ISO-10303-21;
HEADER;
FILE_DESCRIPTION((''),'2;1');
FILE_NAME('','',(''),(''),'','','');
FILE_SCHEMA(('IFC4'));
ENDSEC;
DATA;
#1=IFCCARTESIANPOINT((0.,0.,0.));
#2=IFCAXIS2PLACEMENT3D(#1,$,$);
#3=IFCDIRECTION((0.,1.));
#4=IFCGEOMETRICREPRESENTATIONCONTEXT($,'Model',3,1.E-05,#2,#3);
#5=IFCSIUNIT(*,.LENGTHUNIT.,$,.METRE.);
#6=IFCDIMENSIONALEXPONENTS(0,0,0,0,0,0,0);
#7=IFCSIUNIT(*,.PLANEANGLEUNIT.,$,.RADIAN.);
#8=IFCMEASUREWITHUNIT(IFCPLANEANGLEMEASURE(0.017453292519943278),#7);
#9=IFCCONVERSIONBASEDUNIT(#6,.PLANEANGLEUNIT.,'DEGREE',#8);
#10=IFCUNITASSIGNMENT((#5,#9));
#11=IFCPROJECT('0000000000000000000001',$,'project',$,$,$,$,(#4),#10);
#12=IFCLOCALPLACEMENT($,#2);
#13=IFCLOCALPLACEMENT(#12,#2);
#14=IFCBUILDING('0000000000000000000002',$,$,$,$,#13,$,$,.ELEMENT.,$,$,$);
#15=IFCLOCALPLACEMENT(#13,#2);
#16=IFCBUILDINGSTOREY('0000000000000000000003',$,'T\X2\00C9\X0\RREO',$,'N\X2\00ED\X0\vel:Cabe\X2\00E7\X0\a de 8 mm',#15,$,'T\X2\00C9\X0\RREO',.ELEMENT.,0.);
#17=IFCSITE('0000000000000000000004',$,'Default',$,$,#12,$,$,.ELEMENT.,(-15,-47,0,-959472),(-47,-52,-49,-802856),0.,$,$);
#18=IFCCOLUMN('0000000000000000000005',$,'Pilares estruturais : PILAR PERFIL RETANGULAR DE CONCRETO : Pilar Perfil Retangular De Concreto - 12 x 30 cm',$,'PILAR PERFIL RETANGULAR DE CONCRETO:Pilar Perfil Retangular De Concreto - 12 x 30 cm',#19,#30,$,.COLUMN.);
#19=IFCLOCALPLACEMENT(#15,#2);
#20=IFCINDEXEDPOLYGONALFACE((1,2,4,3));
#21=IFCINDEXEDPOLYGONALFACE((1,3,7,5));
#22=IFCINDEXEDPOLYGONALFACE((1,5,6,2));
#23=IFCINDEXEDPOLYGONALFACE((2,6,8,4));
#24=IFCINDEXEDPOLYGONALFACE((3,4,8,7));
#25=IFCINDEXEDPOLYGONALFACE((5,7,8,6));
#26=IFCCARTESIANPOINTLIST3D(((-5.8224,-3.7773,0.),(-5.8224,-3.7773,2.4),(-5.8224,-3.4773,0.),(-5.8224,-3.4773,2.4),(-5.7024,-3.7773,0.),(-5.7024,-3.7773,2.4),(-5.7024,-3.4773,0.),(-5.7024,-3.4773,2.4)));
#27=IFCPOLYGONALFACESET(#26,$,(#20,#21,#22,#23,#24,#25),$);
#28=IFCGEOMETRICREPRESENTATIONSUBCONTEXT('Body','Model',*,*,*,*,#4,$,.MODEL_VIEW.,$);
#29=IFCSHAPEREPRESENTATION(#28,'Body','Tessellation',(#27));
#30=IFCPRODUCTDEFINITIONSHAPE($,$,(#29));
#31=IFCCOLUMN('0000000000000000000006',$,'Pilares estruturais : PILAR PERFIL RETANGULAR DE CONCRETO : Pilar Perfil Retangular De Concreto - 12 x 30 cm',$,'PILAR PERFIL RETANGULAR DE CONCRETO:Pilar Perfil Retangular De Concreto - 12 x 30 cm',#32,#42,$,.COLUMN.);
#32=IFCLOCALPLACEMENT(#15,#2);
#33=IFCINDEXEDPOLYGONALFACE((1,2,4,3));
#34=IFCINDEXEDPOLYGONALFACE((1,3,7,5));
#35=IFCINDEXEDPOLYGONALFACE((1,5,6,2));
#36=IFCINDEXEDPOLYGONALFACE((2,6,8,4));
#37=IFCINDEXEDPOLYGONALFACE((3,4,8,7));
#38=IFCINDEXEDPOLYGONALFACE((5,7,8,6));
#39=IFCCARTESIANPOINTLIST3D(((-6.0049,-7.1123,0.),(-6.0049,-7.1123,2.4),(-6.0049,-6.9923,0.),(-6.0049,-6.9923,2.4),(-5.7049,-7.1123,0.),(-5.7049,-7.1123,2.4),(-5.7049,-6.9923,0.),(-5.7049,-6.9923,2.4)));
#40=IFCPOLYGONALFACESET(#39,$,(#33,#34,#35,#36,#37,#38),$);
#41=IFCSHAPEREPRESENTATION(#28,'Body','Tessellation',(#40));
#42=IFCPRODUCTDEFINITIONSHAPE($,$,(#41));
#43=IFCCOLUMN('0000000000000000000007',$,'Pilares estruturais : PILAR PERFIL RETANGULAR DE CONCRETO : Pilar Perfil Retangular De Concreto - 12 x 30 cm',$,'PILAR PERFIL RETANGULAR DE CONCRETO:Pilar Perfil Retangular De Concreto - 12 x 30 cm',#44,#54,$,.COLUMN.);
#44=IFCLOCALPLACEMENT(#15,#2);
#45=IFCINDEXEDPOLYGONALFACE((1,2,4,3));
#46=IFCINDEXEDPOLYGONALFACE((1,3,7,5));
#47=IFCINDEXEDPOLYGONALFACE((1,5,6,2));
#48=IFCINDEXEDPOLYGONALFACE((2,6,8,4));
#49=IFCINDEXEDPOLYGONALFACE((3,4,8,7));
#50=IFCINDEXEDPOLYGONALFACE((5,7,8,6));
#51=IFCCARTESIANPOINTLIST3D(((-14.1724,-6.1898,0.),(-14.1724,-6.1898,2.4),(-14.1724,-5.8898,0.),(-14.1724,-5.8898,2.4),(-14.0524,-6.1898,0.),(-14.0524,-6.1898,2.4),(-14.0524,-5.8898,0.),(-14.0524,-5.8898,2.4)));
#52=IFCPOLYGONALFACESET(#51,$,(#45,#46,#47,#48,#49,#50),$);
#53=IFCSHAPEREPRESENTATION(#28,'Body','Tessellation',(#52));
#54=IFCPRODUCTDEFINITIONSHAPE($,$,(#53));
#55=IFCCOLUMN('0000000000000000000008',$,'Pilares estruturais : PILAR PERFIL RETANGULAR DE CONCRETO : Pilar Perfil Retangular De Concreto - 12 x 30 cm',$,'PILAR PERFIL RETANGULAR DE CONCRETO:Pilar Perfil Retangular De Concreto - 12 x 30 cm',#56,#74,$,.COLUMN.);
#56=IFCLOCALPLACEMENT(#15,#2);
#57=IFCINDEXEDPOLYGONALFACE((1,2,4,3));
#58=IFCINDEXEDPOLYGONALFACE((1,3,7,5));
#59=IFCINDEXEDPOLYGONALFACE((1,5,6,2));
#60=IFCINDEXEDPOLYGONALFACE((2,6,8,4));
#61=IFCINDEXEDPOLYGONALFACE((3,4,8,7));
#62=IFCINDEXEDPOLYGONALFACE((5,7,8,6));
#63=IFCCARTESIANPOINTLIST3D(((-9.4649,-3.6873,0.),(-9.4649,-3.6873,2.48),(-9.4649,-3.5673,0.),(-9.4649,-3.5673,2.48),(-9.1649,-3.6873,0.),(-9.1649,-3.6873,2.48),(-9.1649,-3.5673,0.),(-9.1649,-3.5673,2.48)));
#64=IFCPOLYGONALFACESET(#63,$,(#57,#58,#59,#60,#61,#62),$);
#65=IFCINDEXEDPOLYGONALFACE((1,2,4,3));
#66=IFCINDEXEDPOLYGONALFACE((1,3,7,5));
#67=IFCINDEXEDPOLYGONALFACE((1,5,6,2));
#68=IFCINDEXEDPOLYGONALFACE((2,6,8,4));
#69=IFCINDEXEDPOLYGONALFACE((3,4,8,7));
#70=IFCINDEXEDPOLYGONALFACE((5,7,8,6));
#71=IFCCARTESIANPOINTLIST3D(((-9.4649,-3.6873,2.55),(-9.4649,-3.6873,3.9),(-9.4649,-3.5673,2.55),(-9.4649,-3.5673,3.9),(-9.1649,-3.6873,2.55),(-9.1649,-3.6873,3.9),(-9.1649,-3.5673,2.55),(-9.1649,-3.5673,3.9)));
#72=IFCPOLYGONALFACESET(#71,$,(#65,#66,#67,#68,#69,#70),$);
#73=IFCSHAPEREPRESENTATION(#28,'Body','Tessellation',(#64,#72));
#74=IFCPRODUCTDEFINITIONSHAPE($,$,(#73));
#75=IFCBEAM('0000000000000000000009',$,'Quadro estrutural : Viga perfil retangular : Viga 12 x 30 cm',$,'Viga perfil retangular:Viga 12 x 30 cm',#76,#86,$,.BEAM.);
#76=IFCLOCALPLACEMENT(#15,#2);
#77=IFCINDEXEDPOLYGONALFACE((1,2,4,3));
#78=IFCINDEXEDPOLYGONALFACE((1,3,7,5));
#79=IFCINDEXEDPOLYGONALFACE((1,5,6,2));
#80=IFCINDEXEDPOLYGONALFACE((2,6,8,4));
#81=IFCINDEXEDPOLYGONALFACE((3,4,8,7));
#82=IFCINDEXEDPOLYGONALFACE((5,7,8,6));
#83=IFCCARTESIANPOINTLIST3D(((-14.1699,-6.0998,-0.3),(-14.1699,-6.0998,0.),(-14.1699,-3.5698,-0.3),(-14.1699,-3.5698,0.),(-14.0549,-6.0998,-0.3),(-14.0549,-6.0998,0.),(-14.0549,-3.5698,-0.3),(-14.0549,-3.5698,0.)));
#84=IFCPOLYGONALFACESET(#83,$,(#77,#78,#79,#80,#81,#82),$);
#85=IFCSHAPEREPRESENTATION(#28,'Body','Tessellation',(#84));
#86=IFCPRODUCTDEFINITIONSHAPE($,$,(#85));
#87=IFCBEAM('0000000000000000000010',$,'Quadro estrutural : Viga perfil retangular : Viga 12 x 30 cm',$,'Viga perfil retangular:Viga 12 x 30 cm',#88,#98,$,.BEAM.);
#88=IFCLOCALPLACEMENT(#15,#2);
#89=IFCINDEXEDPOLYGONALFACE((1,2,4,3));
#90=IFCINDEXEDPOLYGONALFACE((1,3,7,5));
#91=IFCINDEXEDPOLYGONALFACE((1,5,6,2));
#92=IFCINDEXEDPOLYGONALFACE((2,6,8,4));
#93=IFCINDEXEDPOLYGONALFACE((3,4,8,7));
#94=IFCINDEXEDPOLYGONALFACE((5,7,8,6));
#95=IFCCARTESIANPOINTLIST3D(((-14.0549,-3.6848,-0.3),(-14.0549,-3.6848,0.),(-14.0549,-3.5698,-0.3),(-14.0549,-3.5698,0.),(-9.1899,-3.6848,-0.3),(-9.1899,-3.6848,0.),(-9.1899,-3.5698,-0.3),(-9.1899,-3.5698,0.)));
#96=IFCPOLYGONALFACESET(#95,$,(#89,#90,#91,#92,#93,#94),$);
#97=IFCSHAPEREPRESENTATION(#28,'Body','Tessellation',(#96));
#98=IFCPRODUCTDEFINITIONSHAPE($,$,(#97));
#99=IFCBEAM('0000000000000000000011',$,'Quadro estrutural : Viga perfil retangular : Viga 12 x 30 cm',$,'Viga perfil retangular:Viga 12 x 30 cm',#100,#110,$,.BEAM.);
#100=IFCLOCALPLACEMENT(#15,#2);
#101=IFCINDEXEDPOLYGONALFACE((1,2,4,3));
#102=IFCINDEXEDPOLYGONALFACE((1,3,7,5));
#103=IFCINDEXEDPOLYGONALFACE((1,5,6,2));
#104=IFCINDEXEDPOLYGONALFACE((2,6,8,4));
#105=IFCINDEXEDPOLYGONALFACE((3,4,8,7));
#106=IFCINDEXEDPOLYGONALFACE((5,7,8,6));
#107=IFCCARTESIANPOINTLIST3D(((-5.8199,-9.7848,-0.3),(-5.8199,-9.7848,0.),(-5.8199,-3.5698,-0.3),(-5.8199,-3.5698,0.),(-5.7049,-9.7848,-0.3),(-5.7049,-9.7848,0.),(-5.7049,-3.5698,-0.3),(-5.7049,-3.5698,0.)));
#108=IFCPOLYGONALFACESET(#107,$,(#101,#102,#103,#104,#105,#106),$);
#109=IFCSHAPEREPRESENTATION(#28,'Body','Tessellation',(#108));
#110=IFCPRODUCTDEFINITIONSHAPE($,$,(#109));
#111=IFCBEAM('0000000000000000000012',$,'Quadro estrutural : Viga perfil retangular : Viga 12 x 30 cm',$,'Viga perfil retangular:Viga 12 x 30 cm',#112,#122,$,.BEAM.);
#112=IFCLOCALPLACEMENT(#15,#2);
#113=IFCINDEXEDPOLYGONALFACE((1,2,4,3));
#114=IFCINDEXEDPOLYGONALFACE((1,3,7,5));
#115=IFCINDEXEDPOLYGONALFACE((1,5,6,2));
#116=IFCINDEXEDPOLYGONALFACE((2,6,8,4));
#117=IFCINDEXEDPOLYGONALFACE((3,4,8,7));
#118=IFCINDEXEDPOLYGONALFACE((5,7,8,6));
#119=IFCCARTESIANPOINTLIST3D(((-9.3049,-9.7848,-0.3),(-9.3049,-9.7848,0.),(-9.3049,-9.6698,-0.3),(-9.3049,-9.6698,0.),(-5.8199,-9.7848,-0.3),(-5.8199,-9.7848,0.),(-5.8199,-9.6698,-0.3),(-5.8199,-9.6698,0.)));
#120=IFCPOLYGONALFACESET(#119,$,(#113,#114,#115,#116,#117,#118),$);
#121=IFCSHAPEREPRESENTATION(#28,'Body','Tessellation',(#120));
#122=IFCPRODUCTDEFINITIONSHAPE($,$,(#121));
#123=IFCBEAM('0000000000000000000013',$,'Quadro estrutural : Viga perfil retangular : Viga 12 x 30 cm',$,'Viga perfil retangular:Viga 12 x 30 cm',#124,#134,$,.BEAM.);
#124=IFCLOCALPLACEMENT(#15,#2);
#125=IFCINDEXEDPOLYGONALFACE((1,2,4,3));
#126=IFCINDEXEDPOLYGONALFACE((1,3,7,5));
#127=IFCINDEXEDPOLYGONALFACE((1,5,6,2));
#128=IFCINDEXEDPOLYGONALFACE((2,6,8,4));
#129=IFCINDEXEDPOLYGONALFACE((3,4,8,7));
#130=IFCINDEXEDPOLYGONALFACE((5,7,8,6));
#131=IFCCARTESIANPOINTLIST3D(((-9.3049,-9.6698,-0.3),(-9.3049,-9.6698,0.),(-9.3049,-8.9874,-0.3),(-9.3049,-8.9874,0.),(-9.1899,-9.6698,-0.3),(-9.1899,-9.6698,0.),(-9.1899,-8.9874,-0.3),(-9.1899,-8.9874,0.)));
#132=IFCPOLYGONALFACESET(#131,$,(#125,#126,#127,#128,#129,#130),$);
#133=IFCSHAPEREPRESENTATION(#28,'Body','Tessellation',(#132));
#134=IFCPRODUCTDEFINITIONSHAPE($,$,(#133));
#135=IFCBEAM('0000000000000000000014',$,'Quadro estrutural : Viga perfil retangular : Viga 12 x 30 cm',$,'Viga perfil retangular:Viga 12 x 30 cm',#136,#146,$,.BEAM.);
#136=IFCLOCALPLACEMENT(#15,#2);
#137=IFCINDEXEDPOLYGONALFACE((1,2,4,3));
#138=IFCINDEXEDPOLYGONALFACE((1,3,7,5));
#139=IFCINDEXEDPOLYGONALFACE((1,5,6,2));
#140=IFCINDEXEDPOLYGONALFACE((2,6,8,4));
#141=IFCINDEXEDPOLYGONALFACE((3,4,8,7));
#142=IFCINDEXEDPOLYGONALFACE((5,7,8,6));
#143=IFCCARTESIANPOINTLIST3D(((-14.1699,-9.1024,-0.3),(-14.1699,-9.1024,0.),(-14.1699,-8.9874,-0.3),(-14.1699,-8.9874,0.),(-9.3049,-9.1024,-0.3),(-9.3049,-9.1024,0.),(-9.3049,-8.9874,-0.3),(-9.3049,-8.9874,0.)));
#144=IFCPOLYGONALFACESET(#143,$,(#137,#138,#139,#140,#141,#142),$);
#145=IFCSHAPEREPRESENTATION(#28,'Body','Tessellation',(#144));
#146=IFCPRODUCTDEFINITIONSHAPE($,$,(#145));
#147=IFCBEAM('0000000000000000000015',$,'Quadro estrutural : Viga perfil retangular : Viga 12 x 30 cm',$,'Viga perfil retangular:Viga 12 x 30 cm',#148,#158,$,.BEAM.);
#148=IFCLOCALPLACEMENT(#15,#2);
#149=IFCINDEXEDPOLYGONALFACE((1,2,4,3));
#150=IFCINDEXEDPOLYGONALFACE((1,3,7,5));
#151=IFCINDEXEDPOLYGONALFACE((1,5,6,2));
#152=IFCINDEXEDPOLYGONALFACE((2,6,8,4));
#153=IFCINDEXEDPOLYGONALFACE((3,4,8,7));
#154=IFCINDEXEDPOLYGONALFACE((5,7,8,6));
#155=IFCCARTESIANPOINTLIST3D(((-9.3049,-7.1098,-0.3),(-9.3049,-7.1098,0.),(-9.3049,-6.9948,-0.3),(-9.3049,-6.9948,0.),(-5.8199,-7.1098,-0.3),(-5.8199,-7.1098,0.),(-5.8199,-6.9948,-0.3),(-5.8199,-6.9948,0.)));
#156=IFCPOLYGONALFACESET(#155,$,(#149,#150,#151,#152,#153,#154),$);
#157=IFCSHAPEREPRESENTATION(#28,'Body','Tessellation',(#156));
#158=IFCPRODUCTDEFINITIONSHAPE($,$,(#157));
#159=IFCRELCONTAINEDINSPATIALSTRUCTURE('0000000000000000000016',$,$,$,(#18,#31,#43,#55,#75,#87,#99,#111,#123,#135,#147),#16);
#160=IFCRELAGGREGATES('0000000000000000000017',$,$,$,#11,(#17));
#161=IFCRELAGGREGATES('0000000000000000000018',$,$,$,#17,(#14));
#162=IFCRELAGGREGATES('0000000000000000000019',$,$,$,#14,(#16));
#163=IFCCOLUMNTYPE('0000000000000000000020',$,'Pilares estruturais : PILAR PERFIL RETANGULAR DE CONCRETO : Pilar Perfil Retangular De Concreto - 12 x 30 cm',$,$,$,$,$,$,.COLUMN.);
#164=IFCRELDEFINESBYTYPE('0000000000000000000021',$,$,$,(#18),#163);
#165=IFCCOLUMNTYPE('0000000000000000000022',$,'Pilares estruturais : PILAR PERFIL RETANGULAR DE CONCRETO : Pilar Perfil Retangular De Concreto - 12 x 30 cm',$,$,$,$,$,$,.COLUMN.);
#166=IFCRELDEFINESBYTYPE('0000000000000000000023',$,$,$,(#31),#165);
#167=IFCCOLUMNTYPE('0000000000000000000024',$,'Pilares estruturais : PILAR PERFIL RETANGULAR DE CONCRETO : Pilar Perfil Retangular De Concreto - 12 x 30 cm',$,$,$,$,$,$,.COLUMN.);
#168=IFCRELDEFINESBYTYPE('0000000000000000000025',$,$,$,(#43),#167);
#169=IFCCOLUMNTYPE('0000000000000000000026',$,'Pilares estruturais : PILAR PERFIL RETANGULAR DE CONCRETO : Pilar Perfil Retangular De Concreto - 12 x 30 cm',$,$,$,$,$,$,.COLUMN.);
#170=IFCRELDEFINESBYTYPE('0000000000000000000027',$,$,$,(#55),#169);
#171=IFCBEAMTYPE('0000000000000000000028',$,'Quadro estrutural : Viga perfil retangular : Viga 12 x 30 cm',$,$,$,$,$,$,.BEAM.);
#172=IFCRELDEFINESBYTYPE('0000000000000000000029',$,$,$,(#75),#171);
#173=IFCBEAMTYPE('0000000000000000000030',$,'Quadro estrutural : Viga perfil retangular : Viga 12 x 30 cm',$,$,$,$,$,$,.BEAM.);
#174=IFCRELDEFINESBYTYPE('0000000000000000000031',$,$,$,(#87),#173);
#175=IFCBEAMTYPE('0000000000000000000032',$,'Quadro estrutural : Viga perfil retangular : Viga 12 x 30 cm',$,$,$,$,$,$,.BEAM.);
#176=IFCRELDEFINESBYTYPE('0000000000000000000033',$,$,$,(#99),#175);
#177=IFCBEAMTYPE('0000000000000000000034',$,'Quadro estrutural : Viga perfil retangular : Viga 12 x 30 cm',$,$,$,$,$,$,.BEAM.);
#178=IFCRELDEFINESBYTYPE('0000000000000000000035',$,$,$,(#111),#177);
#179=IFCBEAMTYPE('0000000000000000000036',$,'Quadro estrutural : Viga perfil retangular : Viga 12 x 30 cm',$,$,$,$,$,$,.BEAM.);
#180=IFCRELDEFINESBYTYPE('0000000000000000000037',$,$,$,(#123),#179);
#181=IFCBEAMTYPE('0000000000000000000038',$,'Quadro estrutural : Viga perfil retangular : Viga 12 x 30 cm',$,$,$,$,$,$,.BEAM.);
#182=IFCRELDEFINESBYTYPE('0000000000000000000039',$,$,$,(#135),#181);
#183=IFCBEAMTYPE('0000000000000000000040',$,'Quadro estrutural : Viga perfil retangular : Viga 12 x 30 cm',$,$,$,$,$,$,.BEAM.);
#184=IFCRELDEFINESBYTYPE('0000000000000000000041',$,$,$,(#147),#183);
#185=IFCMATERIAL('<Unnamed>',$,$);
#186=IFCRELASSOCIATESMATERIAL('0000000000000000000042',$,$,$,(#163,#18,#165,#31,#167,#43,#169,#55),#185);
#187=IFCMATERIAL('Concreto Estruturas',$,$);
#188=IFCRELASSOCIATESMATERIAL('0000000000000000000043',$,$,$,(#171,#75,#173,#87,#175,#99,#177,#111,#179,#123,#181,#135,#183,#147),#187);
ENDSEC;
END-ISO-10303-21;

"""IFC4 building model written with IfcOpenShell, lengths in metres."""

from ifc_helpers import new_model, entity, si_unit, converted_unit, direction, frame, origin, place, context, subcontext, project, spatial, indexed_curve, outline, extrude, source, transform, mapped, material, type_object, type_shapes, element, save


model = new_model("IFC4")

# Units and contexts
model_context = context("Model", 3, precision=1e-05, world=origin(), true_north=direction((0.0, 1.0)))
body_context = subcontext(model_context, "Body", "Model", "MODEL_VIEW")
ifc_project = project(units=[si_unit("LENGTHUNIT", "METRE"), converted_unit("PLANEANGLEUNIT", "DEGREE", entity("IfcPlaneAngleMeasure", 0.017453292519943278), si_unit("PLANEANGLEUNIT", "RADIAN"), dimensions=[0, 0, 0, 0, 0, 0, 0])], contexts=[model_context])

# Site, building, storey
site_placement = place(None, origin())
site = spatial("IfcSite", under=ifc_project, at=site_placement, Name="Default", CompositionType="ELEMENT", RefLatitude=(-15, -47, 0, -959472), RefLongitude=(-47, -52, -49, -802856), RefElevation=0.0)
building_placement = place(site_placement, origin())
building = spatial("IfcBuilding", under=site, at=building_placement, CompositionType="ELEMENT")
storey_placement = place(building_placement, origin())
storey = spatial("IfcBuildingStorey", under=building, at=storey_placement, Name="TÉRREO", ObjectType="Nível:Cabeça de 8 mm", LongName="TÉRREO", CompositionType="ELEMENT", Elevation=0.0)

# Columns
ifc_material_1 = material(Name="<Unnamed>")
column_type_1 = type_object("IfcColumnType", Name="Pilares estruturais : PILAR PERFIL RETANGULAR DE CONCRETO : Pilar Perfil Retangular De Concreto - 12 x 30 cm", PredefinedType="COLUMN", material=ifc_material_1)
shared_shape_1 = source(origin(), body_context, "Body", "SweptSolid", [
    extrude(outline(indexed_curve([(-0.06, -0.15), (0.06, -0.15), (0.06, 0.15), (-0.06, 0.15), (-0.06, -0.15)], self_intersect=False)), frame((-5.7624, -3.6273, 0.0), z_axis=(0.0, 0.0, 1.0), x_axis=(-1.0, 0.0, 0.0)), (0.0, 0.0, 1.0), 2.4),
])
type_shapes(column_type_1, [shared_shape_1])
column_1_placement = place(storey_placement, origin())
element("IfcColumn", 1, at=column_1_placement, inside=storey, type_object=column_type_1, material=ifc_material_1, Name="Pilares estruturais : PILAR PERFIL RETANGULAR DE CONCRETO : Pilar Perfil Retangular De Concreto - 12 x 30 cm", ObjectType="PILAR PERFIL RETANGULAR DE CONCRETO:Pilar Perfil Retangular De Concreto - 12 x 30 cm", PredefinedType="COLUMN", context=body_context, shape_type="MappedRepresentation", body=[
    mapped(shared_shape_1, transform((0.0, 0.0, 0.0), scale=1.0)),
])
column_type_2 = type_object("IfcColumnType", Name="Pilares estruturais : PILAR PERFIL RETANGULAR DE CONCRETO : Pilar Perfil Retangular De Concreto - 12 x 30 cm", PredefinedType="COLUMN", material=ifc_material_1)
shared_shape_2 = source(origin(), body_context, "Body", "SweptSolid", [
    extrude(outline(indexed_curve([(-0.06, -0.15), (0.06, -0.15), (0.06, 0.15), (-0.06, 0.15), (-0.06, -0.15)], self_intersect=False)), frame((-5.8549, -7.0523, 0.0), z_axis=(0.0, 0.0, 1.0), x_axis=(0.0, 1.0, 0.0)), (0.0, 0.0, 1.0), 2.4),
])
type_shapes(column_type_2, [shared_shape_2])
column_2_placement = place(storey_placement, origin())
element("IfcColumn", 2, at=column_2_placement, inside=storey, type_object=column_type_2, material=ifc_material_1, Name="Pilares estruturais : PILAR PERFIL RETANGULAR DE CONCRETO : Pilar Perfil Retangular De Concreto - 12 x 30 cm", ObjectType="PILAR PERFIL RETANGULAR DE CONCRETO:Pilar Perfil Retangular De Concreto - 12 x 30 cm", PredefinedType="COLUMN", context=body_context, shape_type="MappedRepresentation", body=[
    mapped(shared_shape_2, transform((0.0, 0.0, 0.0), scale=1.0)),
])
column_type_3 = type_object("IfcColumnType", Name="Pilares estruturais : PILAR PERFIL RETANGULAR DE CONCRETO : Pilar Perfil Retangular De Concreto - 12 x 30 cm", PredefinedType="COLUMN", material=ifc_material_1)
shared_shape_3 = source(origin(), body_context, "Body", "SweptSolid", [
    extrude(outline(indexed_curve([(-0.06, -0.15), (0.06, -0.15), (0.06, 0.15), (-0.06, 0.15), (-0.06, -0.15)], self_intersect=False)), frame((-14.1124, -6.0398, 0.0), z_axis=(0.0, 0.0, 1.0), x_axis=(-1.0, 0.0, 0.0)), (0.0, 0.0, 1.0), 2.4),
])
type_shapes(column_type_3, [shared_shape_3])
column_3_placement = place(storey_placement, origin())
element("IfcColumn", 3, at=column_3_placement, inside=storey, type_object=column_type_3, material=ifc_material_1, Name="Pilares estruturais : PILAR PERFIL RETANGULAR DE CONCRETO : Pilar Perfil Retangular De Concreto - 12 x 30 cm", ObjectType="PILAR PERFIL RETANGULAR DE CONCRETO:Pilar Perfil Retangular De Concreto - 12 x 30 cm", PredefinedType="COLUMN", context=body_context, shape_type="MappedRepresentation", body=[
    mapped(shared_shape_3, transform((0.0, 0.0, 0.0), scale=1.0)),
])
column_type_4 = type_object("IfcColumnType", Name="Pilares estruturais : PILAR PERFIL RETANGULAR DE CONCRETO : Pilar Perfil Retangular De Concreto - 12 x 30 cm", PredefinedType="COLUMN", material=ifc_material_1)
shared_shape_4 = source(origin(), body_context, "Body", "SweptSolid", [
    extrude(outline(indexed_curve([(-0.06, -0.15), (0.06, -0.15), (0.06, 0.15), (-0.06, 0.15), (-0.06, -0.15)], self_intersect=False)), frame((-9.3149, -3.6273, 0.0), z_axis=(0.0, 0.0, 1.0), x_axis=(0.0, 1.0, 0.0)), (0.0, 0.0, 1.0), 2.48),
    extrude(outline(indexed_curve([(-0.06, -0.15), (0.06, -0.15), (0.06, 0.15), (-0.06, 0.15), (-0.06, -0.15)], self_intersect=False)), frame((-9.3149, -3.6273, 2.55), z_axis=(0.0, 0.0, 1.0), x_axis=(0.0, -1.0, 0.0)), (0.0, 0.0, 1.0), 1.35),
])
type_shapes(column_type_4, [shared_shape_4])
column_4_placement = place(storey_placement, origin())
element("IfcColumn", 4, at=column_4_placement, inside=storey, type_object=column_type_4, material=ifc_material_1, Name="Pilares estruturais : PILAR PERFIL RETANGULAR DE CONCRETO : Pilar Perfil Retangular De Concreto - 12 x 30 cm", ObjectType="PILAR PERFIL RETANGULAR DE CONCRETO:Pilar Perfil Retangular De Concreto - 12 x 30 cm", PredefinedType="COLUMN", context=body_context, shape_type="MappedRepresentation", body=[
    mapped(shared_shape_4, transform((0.0, 0.0, 0.0), scale=1.0)),
])

# Beams
ifc_material_2 = material(Name="Concreto Estruturas")
beam_type_1 = type_object("IfcBeamType", Name="Quadro estrutural : Viga perfil retangular : Viga 12 x 30 cm", PredefinedType="BEAM", material=ifc_material_2)
shared_shape_5 = source(origin(), body_context, "Body", "SweptSolid", [
    extrude(outline(indexed_curve([(-0.0575, -0.15), (0.0575, -0.15), (0.0575, 0.15), (-0.0575, 0.15), (-0.0575, -0.15)], self_intersect=False)), frame((-14.1124, -6.0998, -0.15), z_axis=(0.0, 1.0, 0.0), x_axis=(-1.0, 0.0, 0.0)), (0.0, 0.0, 1.0), 2.53),
])
type_shapes(beam_type_1, [shared_shape_5])
beam_1_placement = place(storey_placement, origin())
element("IfcBeam", 5, at=beam_1_placement, inside=storey, type_object=beam_type_1, material=ifc_material_2, Name="Quadro estrutural : Viga perfil retangular : Viga 12 x 30 cm", ObjectType="Viga perfil retangular:Viga 12 x 30 cm", PredefinedType="BEAM", context=body_context, shape_type="MappedRepresentation", body=[
    mapped(shared_shape_5, transform((0.0, 0.0, 0.0), scale=1.0)),
])
beam_type_2 = type_object("IfcBeamType", Name="Quadro estrutural : Viga perfil retangular : Viga 12 x 30 cm", PredefinedType="BEAM", material=ifc_material_2)
shared_shape_6 = source(origin(), body_context, "Body", "SweptSolid", [
    extrude(outline(indexed_curve([(-0.15, -0.0575), (0.15, -0.0575), (0.15, 0.0575), (-0.15, 0.0575), (-0.15, -0.0575)], self_intersect=False)), frame((-14.0549, -3.6273, -0.15), z_axis=(1.0, 0.0, 0.0), x_axis=(0.0, 0.0, -1.0)), (0.0, 0.0, 1.0), 4.865),
])
type_shapes(beam_type_2, [shared_shape_6])
beam_2_placement = place(storey_placement, origin())
element("IfcBeam", 6, at=beam_2_placement, inside=storey, type_object=beam_type_2, material=ifc_material_2, Name="Quadro estrutural : Viga perfil retangular : Viga 12 x 30 cm", ObjectType="Viga perfil retangular:Viga 12 x 30 cm", PredefinedType="BEAM", context=body_context, shape_type="MappedRepresentation", body=[
    mapped(shared_shape_6, transform((0.0, 0.0, 0.0), scale=1.0)),
])
beam_type_3 = type_object("IfcBeamType", Name="Quadro estrutural : Viga perfil retangular : Viga 12 x 30 cm", PredefinedType="BEAM", material=ifc_material_2)
shared_shape_7 = source(origin(), body_context, "Body", "SweptSolid", [
    extrude(outline(indexed_curve([(-0.0575, -0.15), (0.0575, -0.15), (0.0575, 0.15), (-0.0575, 0.15), (-0.0575, -0.15)], self_intersect=False)), frame((-5.7624, -3.5698, -0.15), z_axis=(0.0, -1.0, 0.0), x_axis=(-1.0, 0.0, 0.0)), (0.0, 0.0, 1.0), 6.215),
])
type_shapes(beam_type_3, [shared_shape_7])
beam_3_placement = place(storey_placement, origin())
element("IfcBeam", 7, at=beam_3_placement, inside=storey, type_object=beam_type_3, material=ifc_material_2, Name="Quadro estrutural : Viga perfil retangular : Viga 12 x 30 cm", ObjectType="Viga perfil retangular:Viga 12 x 30 cm", PredefinedType="BEAM", context=body_context, shape_type="MappedRepresentation", body=[
    mapped(shared_shape_7, transform((0.0, 0.0, 0.0), scale=1.0)),
])
beam_type_4 = type_object("IfcBeamType", Name="Quadro estrutural : Viga perfil retangular : Viga 12 x 30 cm", PredefinedType="BEAM", material=ifc_material_2)
shared_shape_8 = source(origin(), body_context, "Body", "SweptSolid", [
    extrude(outline(indexed_curve([(-0.15, -0.0575), (0.15, -0.0575), (0.15, 0.0575), (-0.15, 0.0575), (-0.15, -0.0575)], self_intersect=False)), frame((-5.8199, -9.7273, -0.15), z_axis=(-1.0, 0.0, 0.0), x_axis=(0.0, 0.0, -1.0)), (0.0, 0.0, 1.0), 3.485),
])
type_shapes(beam_type_4, [shared_shape_8])
beam_4_placement = place(storey_placement, origin())
element("IfcBeam", 8, at=beam_4_placement, inside=storey, type_object=beam_type_4, material=ifc_material_2, Name="Quadro estrutural : Viga perfil retangular : Viga 12 x 30 cm", ObjectType="Viga perfil retangular:Viga 12 x 30 cm", PredefinedType="BEAM", context=body_context, shape_type="MappedRepresentation", body=[
    mapped(shared_shape_8, transform((0.0, 0.0, 0.0), scale=1.0)),
])
beam_type_5 = type_object("IfcBeamType", Name="Quadro estrutural : Viga perfil retangular : Viga 12 x 30 cm", PredefinedType="BEAM", material=ifc_material_2)
shared_shape_9 = source(origin(), body_context, "Body", "SweptSolid", [
    extrude(outline(indexed_curve([(-0.0575, -0.15), (0.0575, -0.15), (0.0575, 0.15), (-0.0575, 0.15), (-0.0575, -0.15)], self_intersect=False)), frame((-9.2474, -9.6698, -0.15), z_axis=(0.0, 1.0, 0.0), x_axis=(-1.0, 0.0, 0.0)), (0.0, 0.0, 1.0), 0.6824),
])
type_shapes(beam_type_5, [shared_shape_9])
beam_5_placement = place(storey_placement, origin())
element("IfcBeam", 9, at=beam_5_placement, inside=storey, type_object=beam_type_5, material=ifc_material_2, Name="Quadro estrutural : Viga perfil retangular : Viga 12 x 30 cm", ObjectType="Viga perfil retangular:Viga 12 x 30 cm", PredefinedType="BEAM", context=body_context, shape_type="MappedRepresentation", body=[
    mapped(shared_shape_9, transform((0.0, 0.0, 0.0), scale=1.0)),
])
beam_type_6 = type_object("IfcBeamType", Name="Quadro estrutural : Viga perfil retangular : Viga 12 x 30 cm", PredefinedType="BEAM", material=ifc_material_2)
shared_shape_10 = source(origin(), body_context, "Body", "SweptSolid", [
    extrude(outline(indexed_curve([(-0.15, -0.0575), (0.15, -0.0575), (0.15, 0.0575), (-0.15, 0.0575), (-0.15, -0.0575)], self_intersect=False)), frame((-9.3049, -9.0449, -0.15), z_axis=(-1.0, 0.0, 0.0), x_axis=(0.0, 0.0, -1.0)), (0.0, 0.0, 1.0), 4.865),
])
type_shapes(beam_type_6, [shared_shape_10])
beam_6_placement = place(storey_placement, origin())
element("IfcBeam", 10, at=beam_6_placement, inside=storey, type_object=beam_type_6, material=ifc_material_2, Name="Quadro estrutural : Viga perfil retangular : Viga 12 x 30 cm", ObjectType="Viga perfil retangular:Viga 12 x 30 cm", PredefinedType="BEAM", context=body_context, shape_type="MappedRepresentation", body=[
    mapped(shared_shape_10, transform((0.0, 0.0, 0.0), scale=1.0)),
])
beam_type_7 = type_object("IfcBeamType", Name="Quadro estrutural : Viga perfil retangular : Viga 12 x 30 cm", PredefinedType="BEAM", material=ifc_material_2)
shared_shape_11 = source(origin(), body_context, "Body", "SweptSolid", [
    extrude(outline(indexed_curve([(-0.15, -0.0575), (0.15, -0.0575), (0.15, 0.0575), (-0.15, 0.0575), (-0.15, -0.0575)], self_intersect=False)), frame((-9.3049, -7.0523, -0.15), z_axis=(1.0, 0.0, 0.0), x_axis=(0.0, 0.0, -1.0)), (0.0, 0.0, 1.0), 3.485),
])
type_shapes(beam_type_7, [shared_shape_11])
beam_7_placement = place(storey_placement, origin())
element("IfcBeam", 11, at=beam_7_placement, inside=storey, type_object=beam_type_7, material=ifc_material_2, Name="Quadro estrutural : Viga perfil retangular : Viga 12 x 30 cm", ObjectType="Viga perfil retangular:Viga 12 x 30 cm", PredefinedType="BEAM", context=body_context, shape_type="MappedRepresentation", body=[
    mapped(shared_shape_11, transform((0.0, 0.0, 0.0), scale=1.0)),
])

save(model, "model.ifc")
